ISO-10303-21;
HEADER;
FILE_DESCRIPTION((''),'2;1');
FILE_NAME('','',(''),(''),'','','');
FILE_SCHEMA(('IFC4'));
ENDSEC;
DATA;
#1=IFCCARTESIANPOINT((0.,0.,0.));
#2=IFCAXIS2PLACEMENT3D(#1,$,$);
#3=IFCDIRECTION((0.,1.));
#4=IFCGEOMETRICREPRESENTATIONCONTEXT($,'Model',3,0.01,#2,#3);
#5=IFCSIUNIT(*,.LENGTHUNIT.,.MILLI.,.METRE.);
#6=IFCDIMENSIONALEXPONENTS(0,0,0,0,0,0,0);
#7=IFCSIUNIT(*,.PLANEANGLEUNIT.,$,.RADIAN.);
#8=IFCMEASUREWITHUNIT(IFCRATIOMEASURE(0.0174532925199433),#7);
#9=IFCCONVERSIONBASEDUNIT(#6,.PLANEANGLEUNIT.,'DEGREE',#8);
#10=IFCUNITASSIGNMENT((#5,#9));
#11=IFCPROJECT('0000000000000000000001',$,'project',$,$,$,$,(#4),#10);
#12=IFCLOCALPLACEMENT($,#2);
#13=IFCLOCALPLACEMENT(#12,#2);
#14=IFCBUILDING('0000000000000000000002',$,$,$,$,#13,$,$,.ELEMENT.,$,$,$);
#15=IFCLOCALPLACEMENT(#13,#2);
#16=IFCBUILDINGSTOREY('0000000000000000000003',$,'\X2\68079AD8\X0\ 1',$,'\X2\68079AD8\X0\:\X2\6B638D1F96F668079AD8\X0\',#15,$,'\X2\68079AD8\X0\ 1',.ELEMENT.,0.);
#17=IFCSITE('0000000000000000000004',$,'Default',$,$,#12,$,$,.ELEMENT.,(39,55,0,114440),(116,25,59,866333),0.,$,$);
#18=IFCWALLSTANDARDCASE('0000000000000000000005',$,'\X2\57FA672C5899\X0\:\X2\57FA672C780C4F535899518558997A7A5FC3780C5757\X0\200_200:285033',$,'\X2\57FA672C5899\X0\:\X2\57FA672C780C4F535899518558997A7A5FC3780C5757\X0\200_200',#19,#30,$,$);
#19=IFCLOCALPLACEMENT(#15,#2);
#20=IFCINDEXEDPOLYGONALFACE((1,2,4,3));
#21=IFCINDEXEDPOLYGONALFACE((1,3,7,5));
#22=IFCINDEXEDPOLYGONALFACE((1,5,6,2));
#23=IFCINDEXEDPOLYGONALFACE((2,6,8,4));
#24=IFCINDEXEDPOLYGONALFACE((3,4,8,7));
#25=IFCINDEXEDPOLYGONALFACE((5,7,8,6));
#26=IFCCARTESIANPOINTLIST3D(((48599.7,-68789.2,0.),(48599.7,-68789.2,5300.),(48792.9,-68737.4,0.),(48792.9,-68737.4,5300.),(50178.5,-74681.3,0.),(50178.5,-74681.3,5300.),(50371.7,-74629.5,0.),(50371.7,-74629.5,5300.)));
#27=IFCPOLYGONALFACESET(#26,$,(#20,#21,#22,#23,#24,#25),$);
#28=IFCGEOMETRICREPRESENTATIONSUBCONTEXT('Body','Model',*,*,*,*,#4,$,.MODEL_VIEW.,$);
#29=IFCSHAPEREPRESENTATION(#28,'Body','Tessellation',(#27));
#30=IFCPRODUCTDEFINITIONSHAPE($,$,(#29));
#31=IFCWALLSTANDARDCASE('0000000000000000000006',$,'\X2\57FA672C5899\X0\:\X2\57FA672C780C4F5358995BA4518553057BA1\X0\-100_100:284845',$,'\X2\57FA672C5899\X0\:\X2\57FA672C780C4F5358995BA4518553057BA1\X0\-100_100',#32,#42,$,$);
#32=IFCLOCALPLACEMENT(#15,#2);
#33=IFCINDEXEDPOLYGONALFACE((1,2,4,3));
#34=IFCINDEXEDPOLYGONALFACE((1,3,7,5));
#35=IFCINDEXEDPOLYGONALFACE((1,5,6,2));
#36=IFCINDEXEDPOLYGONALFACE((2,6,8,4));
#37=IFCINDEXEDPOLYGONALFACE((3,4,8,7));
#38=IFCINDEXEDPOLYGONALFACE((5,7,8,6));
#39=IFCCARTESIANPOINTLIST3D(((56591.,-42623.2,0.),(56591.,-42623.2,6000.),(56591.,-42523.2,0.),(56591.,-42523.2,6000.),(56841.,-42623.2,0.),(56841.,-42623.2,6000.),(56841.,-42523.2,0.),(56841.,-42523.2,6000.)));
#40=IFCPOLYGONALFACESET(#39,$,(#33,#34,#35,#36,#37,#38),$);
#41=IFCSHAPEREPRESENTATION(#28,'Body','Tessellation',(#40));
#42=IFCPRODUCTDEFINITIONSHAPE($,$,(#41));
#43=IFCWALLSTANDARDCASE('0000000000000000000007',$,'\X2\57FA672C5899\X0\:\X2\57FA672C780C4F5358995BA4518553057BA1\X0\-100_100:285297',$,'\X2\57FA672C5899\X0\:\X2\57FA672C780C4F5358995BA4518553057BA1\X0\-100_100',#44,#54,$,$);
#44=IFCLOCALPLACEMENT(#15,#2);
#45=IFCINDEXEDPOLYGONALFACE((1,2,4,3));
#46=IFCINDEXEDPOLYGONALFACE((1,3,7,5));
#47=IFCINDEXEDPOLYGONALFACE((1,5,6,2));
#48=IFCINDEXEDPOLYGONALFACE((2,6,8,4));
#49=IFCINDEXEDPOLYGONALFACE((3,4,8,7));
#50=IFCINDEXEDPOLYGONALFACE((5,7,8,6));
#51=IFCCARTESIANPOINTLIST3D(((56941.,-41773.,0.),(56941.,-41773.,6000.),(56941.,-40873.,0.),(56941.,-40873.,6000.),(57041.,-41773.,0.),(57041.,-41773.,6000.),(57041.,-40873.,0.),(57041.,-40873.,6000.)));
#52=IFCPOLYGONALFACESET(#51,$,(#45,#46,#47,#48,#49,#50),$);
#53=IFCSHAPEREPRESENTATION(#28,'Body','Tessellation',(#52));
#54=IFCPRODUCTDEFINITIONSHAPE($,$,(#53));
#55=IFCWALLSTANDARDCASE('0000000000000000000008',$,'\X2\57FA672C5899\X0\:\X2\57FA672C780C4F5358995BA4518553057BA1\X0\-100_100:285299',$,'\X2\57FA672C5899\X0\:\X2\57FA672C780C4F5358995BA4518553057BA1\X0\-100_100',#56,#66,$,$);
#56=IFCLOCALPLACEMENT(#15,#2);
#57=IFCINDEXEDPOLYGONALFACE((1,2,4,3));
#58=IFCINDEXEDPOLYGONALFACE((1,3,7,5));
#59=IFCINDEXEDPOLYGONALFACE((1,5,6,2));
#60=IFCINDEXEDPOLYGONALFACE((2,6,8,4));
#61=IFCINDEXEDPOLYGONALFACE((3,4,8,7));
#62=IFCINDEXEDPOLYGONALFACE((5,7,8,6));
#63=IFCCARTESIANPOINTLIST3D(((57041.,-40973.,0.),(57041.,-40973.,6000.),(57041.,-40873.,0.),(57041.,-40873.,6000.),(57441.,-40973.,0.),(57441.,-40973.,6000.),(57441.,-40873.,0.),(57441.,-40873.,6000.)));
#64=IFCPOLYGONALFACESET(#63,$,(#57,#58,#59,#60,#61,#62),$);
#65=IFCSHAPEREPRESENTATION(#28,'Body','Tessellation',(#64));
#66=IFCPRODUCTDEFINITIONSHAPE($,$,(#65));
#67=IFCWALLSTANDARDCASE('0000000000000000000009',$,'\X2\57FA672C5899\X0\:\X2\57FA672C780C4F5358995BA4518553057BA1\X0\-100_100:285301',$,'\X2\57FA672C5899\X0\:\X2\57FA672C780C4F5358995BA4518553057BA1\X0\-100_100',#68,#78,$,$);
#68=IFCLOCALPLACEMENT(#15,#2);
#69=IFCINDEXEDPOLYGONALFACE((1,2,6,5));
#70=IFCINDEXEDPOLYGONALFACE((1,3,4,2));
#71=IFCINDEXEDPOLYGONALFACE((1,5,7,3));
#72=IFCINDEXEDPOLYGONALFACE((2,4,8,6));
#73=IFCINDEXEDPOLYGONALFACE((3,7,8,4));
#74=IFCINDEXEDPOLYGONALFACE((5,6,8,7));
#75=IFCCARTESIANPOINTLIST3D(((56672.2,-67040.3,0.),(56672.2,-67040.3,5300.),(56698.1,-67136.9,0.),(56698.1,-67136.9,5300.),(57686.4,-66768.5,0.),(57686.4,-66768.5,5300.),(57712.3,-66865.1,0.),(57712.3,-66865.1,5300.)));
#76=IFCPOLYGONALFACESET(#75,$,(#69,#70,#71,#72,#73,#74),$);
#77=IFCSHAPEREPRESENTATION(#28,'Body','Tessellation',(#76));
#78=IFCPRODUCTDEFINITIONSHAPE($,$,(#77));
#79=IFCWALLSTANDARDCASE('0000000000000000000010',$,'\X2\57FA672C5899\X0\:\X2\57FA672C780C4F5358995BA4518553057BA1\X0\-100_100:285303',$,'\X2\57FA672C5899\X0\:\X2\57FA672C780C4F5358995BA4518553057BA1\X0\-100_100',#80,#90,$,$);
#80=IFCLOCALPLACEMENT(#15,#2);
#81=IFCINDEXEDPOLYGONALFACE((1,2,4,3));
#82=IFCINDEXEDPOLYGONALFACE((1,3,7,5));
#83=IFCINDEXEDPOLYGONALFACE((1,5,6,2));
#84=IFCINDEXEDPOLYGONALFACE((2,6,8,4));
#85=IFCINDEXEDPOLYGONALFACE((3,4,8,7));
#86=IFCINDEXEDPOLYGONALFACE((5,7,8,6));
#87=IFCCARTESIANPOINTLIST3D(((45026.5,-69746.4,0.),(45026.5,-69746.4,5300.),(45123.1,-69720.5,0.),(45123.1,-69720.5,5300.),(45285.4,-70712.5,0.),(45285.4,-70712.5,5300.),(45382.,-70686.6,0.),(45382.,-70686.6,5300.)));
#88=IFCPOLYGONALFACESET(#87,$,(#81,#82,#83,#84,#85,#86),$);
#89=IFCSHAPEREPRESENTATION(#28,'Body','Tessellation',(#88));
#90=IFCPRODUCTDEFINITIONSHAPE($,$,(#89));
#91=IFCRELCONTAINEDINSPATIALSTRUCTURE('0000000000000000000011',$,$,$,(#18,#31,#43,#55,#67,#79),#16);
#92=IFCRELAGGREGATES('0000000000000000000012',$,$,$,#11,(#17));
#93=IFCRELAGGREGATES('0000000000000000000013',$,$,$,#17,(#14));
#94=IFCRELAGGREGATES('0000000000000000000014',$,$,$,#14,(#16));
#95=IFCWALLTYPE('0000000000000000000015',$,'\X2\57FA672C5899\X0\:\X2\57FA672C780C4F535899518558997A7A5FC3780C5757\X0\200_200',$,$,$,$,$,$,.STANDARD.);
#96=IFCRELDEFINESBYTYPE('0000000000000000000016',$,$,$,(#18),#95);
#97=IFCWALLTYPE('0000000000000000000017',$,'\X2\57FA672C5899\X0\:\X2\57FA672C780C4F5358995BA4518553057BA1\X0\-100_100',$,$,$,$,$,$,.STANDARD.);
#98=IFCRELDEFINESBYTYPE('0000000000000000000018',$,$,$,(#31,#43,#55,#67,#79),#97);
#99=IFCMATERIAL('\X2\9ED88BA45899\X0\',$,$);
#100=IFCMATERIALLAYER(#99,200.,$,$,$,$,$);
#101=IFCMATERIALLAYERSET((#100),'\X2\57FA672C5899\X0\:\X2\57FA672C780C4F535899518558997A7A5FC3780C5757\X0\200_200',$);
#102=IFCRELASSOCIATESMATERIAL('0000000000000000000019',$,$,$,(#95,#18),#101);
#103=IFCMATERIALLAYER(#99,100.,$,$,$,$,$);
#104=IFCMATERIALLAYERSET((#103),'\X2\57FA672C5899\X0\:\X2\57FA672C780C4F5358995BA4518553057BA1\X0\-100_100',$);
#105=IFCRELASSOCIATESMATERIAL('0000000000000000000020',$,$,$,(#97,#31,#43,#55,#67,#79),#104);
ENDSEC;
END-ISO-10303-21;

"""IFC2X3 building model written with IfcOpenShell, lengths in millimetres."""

from ifc_helpers import new_model, entity, si_unit, converted_unit, direction, frame, frame_2d, origin, place, context, subcontext, project, spatial, rectangle, extrude, material, layer, layer_set, layer_usage, type_object, element, save


model = new_model("IFC2X3")

# Units and contexts
model_context = context("Model", 3, precision=0.01, world=origin(), true_north=direction((0.0, 1.0)))
body_context = subcontext(model_context, "Body", "Model", "MODEL_VIEW")
ifc_project = project(units=[si_unit("LENGTHUNIT", "METRE", prefix="MILLI"), converted_unit("PLANEANGLEUNIT", "DEGREE", entity("IfcRatioMeasure", 0.0174532925199433), si_unit("PLANEANGLEUNIT", "RADIAN"), dimensions=[0, 0, 0, 0, 0, 0, 0])], contexts=[model_context])

# Site, building, storey
site_placement = place(None, origin())
site = spatial("IfcSite", under=ifc_project, at=site_placement, Name="Default", CompositionType="ELEMENT", RefLatitude=(39, 55, 0, 114440), RefLongitude=(116, 25, 59, 866333), RefElevation=0.0)
building_placement = place(site_placement, origin())
building = spatial("IfcBuilding", under=site, at=building_placement, CompositionType="ELEMENT")
storey_placement = place(building_placement, origin())
storey = spatial("IfcBuildingStorey", under=building, at=storey_placement, Name="标高 1", ObjectType="标高:正负零标高", LongName="标高 1", CompositionType="ELEMENT", Elevation=0.0)

# Shared definitions
ifc_material = material(Name="默认墙")

# Shared definitions
ifc_layer_1 = layer(ifc_material, 200.0)
ifc_layer_set_1 = layer_set([ifc_layer_1], Name="基本墙:基本砌体墙内墙空心砌块200_200")
wall_type_1 = type_object("IfcWallType", Name="基本墙:基本砌体墙内墙空心砌块200_200", PredefinedType="STANDARD", material=ifc_layer_set_1)

# Walls
ifc_layer_usage_1 = layer_usage(ifc_layer_set_1, "AXIS2", "NEGATIVE", 100.0)
wall_1_placement = place(building_placement, frame((50275.1, -74655.4, 0.0), z_axis=(0.0, 0.0, 1.0), x_axis=(-0.258819, 0.965926, 0.0)))
element("IfcWallStandardCase", 1, at=wall_1_placement, inside=storey, type_object=wall_type_1, material=ifc_layer_usage_1, Name="基本墙:基本砌体墙内墙空心砌块200_200:285033", ObjectType="基本墙:基本砌体墙内墙空心砌块200_200", context=body_context, shape_type="SweptSolid", body=[
    extrude(rectangle(XDim=6100.0, YDim=200.0, at=frame_2d((3050.0, 0.0), x_axis=(-1.0, 0.0))), origin(), (0.0, 0.0, 1.0), 5300.0),
])
ifc_layer_2 = layer(ifc_material, 100.0)
ifc_layer_set_2 = layer_set([ifc_layer_2], Name="基本墙:基本砌体墙室内包管-100_100")
ifc_layer_usage_2 = layer_usage(ifc_layer_set_2, "AXIS2", "NEGATIVE", 50.0)
wall_type_2 = type_object("IfcWallType", Name="基本墙:基本砌体墙室内包管-100_100", PredefinedType="STANDARD", material=ifc_layer_set_2)
wall_2_placement = place(building_placement, frame((56841.0, -42573.2, 0.0), z_axis=(0.0, 0.0, 1.0), x_axis=(-1.0, 0.0, 0.0)))
element("IfcWallStandardCase", 2, at=wall_2_placement, inside=storey, type_object=wall_type_2, material=ifc_layer_usage_2, Name="基本墙:基本砌体墙室内包管-100_100:284845", ObjectType="基本墙:基本砌体墙室内包管-100_100", context=body_context, shape_type="SweptSolid", body=[
    extrude(rectangle(XDim=250.0, YDim=100.0, at=frame_2d((125.0, 0.0), x_axis=(-1.0, 0.0))), origin(), (0.0, 0.0, 1.0), 6000.0),
])
ifc_layer_usage_3 = layer_usage(ifc_layer_set_2, "AXIS2", "NEGATIVE", 50.0)
wall_3_placement = place(building_placement, frame((56991.0, -40873.0, 0.0), z_axis=(0.0, 0.0, 1.0), x_axis=(0.0, -1.0, 0.0)))
element("IfcWallStandardCase", 3, at=wall_3_placement, inside=storey, type_object=wall_type_2, material=ifc_layer_usage_3, Name="基本墙:基本砌体墙室内包管-100_100:285297", ObjectType="基本墙:基本砌体墙室内包管-100_100", context=body_context, shape_type="SweptSolid", body=[
    extrude(rectangle(XDim=900.0, YDim=100.0, at=frame_2d((450.0, 0.0), x_axis=(-1.0, 0.0))), origin(), (0.0, 0.0, 1.0), 6000.0),
])
ifc_layer_usage_4 = layer_usage(ifc_layer_set_2, "AXIS2", "NEGATIVE", 50.0)
wall_4_placement = place(building_placement, frame((57441.0, -40923.0, 0.0), z_axis=(0.0, 0.0, 1.0), x_axis=(-1.0, 0.0, 0.0)))
element("IfcWallStandardCase", 4, at=wall_4_placement, inside=storey, type_object=wall_type_2, material=ifc_layer_usage_4, Name="基本墙:基本砌体墙室内包管-100_100:285299", ObjectType="基本墙:基本砌体墙室内包管-100_100", context=body_context, shape_type="SweptSolid", body=[
    extrude(rectangle(XDim=400.0, YDim=100.0, at=frame_2d((200.0, 0.0), x_axis=(-1.0, 0.0))), origin(), (0.0, 0.0, 1.0), 6000.0),
])
ifc_layer_usage_5 = layer_usage(ifc_layer_set_2, "AXIS2", "NEGATIVE", 50.0)
wall_5_placement = place(building_placement, frame((56685.1, -67088.6, 0.0), z_axis=(0.0, 0.0, 1.0), x_axis=(0.965926, 0.258819, 0.0)))
element("IfcWallStandardCase", 5, at=wall_5_placement, inside=storey, type_object=wall_type_2, material=ifc_layer_usage_5, Name="基本墙:基本砌体墙室内包管-100_100:285301", ObjectType="基本墙:基本砌体墙室内包管-100_100", context=body_context, shape_type="SweptSolid", body=[
    extrude(rectangle(XDim=1050.0, YDim=100.0, at=frame_2d((525.0, 0.0), x_axis=(-1.0, 0.0))), origin(), (0.0, 0.0, 1.0), 5300.0),
])
ifc_layer_usage_6 = layer_usage(ifc_layer_set_2, "AXIS2", "NEGATIVE", 50.0)
wall_6_placement = place(building_placement, frame((45333.7, -70699.5, 0.0), z_axis=(0.0, 0.0, 1.0), x_axis=(-0.258819, 0.965926, 0.0)))
element("IfcWallStandardCase", 6, at=wall_6_placement, inside=storey, type_object=wall_type_2, material=ifc_layer_usage_6, Name="基本墙:基本砌体墙室内包管-100_100:285303", ObjectType="基本墙:基本砌体墙室内包管-100_100", context=body_context, shape_type="SweptSolid", body=[
    extrude(rectangle(XDim=1000.1, YDim=100.0, at=frame_2d((500.1, 0.0), x_axis=(-1.0, 0.0))), origin(), (0.0, 0.0, 1.0), 5300.0),
])

save(model, "model.ifc")
